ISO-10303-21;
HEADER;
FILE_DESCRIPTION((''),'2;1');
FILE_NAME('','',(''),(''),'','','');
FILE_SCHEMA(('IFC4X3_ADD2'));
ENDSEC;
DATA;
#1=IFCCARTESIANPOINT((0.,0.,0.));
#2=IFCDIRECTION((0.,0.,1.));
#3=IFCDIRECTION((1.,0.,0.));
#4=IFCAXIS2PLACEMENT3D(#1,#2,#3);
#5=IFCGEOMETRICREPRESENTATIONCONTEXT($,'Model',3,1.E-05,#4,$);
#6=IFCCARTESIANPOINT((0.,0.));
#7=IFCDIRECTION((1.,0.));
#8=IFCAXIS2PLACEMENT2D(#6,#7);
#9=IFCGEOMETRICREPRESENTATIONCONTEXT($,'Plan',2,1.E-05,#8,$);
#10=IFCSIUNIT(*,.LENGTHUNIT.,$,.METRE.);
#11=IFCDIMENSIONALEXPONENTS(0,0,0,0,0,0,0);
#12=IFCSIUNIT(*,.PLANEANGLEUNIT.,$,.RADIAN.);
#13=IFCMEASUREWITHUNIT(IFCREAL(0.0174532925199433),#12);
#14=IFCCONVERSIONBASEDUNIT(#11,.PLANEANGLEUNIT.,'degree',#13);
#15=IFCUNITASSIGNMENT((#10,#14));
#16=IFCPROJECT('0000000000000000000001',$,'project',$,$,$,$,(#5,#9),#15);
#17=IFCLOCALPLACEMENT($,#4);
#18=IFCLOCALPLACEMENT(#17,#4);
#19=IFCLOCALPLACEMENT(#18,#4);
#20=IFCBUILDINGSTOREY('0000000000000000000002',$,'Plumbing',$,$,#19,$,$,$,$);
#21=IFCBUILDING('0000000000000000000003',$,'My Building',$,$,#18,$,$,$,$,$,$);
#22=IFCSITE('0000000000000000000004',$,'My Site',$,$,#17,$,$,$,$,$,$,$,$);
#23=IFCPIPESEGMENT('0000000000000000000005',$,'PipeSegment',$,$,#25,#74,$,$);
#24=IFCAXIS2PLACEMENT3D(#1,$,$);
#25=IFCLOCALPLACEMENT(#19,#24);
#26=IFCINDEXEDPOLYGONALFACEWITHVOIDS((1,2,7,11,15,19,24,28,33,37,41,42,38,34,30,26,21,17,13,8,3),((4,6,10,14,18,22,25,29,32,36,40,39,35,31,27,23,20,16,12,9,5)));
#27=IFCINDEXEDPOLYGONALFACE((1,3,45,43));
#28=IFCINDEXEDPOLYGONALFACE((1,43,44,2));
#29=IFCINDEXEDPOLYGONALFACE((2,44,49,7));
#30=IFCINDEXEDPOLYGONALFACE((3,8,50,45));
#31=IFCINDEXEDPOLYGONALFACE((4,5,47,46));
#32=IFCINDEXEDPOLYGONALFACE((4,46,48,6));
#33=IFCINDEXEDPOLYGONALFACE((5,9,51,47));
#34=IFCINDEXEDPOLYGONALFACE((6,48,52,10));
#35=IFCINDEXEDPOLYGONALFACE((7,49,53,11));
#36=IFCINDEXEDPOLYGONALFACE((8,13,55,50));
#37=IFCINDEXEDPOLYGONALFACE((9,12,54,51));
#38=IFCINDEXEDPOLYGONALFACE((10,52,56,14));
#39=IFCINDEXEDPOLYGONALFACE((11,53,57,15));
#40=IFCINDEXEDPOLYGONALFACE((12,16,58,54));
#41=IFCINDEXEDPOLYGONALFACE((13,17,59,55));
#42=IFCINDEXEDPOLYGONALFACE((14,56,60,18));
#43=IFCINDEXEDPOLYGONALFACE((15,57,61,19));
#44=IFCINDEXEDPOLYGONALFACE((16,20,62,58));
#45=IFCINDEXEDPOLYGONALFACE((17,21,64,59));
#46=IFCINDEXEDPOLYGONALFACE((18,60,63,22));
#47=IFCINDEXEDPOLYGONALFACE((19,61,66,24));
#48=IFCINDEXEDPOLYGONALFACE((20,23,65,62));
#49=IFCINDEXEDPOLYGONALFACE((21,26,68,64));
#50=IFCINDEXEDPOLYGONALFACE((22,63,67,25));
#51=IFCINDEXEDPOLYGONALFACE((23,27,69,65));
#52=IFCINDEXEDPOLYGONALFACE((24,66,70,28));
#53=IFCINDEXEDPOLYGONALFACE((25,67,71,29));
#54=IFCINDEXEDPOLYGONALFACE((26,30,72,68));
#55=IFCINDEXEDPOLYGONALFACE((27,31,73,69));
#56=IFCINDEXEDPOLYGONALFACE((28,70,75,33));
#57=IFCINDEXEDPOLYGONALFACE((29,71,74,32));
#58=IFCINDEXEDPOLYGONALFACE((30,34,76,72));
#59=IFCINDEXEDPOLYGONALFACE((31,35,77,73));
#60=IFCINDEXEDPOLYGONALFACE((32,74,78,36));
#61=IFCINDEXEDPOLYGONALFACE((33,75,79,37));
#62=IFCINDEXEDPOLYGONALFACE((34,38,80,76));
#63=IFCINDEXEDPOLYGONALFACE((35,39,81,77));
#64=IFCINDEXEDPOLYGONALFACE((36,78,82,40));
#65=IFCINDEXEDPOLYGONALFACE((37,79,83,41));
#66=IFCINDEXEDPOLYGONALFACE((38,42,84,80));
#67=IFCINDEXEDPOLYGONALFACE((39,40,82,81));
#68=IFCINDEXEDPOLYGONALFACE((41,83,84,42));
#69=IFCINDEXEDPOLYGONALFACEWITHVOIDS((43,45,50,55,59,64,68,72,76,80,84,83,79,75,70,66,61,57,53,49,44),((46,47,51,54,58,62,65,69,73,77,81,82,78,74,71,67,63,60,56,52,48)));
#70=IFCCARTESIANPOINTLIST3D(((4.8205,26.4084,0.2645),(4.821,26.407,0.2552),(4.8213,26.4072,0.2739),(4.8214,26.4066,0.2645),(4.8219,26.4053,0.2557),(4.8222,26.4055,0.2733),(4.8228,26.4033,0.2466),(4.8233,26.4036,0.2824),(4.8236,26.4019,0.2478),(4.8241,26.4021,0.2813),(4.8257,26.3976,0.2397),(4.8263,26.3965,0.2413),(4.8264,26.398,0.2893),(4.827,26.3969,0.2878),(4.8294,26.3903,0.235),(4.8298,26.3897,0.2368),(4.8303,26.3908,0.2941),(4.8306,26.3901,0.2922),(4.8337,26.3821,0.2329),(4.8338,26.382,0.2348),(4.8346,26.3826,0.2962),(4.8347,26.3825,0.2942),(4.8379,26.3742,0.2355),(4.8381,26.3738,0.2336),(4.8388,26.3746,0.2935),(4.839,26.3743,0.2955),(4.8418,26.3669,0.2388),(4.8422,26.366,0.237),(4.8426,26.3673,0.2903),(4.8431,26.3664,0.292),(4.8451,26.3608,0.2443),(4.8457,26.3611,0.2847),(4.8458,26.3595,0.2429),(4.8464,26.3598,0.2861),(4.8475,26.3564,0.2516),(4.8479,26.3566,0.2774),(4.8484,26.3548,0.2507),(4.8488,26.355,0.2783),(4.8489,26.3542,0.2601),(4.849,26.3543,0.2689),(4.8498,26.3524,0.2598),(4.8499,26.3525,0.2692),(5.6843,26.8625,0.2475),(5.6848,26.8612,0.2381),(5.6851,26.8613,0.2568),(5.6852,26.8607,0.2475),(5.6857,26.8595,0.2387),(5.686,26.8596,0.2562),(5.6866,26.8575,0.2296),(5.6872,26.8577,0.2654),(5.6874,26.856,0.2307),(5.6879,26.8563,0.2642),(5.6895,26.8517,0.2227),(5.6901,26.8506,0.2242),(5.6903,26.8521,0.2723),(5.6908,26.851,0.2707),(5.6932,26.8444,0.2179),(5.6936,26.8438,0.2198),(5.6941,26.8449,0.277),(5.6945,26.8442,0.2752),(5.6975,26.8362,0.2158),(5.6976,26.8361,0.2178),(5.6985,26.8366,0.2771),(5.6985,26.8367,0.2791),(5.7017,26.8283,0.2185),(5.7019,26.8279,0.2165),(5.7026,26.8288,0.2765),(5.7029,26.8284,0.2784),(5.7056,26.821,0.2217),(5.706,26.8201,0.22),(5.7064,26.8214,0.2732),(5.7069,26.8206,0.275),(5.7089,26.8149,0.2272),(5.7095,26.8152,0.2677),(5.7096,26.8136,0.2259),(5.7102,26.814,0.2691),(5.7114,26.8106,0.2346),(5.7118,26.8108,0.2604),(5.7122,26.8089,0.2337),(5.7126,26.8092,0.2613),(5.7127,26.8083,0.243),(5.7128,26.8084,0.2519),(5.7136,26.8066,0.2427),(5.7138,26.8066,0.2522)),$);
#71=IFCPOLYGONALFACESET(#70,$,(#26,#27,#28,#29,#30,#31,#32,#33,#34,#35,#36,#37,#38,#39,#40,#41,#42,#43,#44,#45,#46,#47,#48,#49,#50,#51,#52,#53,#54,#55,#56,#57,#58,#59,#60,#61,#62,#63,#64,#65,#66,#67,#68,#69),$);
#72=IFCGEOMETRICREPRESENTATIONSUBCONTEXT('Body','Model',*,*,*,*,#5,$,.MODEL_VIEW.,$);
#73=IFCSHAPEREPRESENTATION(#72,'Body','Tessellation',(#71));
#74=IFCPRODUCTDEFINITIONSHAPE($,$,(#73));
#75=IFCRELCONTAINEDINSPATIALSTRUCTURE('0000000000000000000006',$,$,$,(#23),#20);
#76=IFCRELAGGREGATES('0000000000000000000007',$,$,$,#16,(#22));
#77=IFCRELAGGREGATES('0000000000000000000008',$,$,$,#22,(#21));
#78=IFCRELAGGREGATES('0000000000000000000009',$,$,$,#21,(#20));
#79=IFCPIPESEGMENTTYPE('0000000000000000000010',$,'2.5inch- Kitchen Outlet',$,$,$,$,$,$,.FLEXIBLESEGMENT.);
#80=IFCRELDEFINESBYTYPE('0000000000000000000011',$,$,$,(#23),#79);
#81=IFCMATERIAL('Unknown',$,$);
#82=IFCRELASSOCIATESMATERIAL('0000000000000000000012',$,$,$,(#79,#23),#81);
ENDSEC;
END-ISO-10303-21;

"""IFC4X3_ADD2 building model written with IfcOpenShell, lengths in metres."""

from ifc_helpers import new_model, entity, si_unit, converted_unit, frame, origin_with_axes, origin_2d_with_axis, place, context, subcontext, project, spatial, hollow_circle, extrude, material, material_profile, profile_set, profile_usage, type_object, element, save


model = new_model("IFC4X3_ADD2")

# Units and contexts
model_context = context("Model", 3, precision=1e-05, world=origin_with_axes())
plan_context = context("Plan", 2, precision=1e-05, world=origin_2d_with_axis())
body_context = subcontext(model_context, "Body", "Model", "MODEL_VIEW")
ifc_project = project(units=[si_unit("LENGTHUNIT", "METRE"), converted_unit("PLANEANGLEUNIT", "degree", entity("IfcReal", 0.0174532925199433), si_unit("PLANEANGLEUNIT", "RADIAN"), dimensions=[0, 0, 0, 0, 0, 0, 0])], contexts=[model_context, plan_context])

# Site, building, storey
site_placement = place(None, origin_with_axes())
site = spatial("IfcSite", under=ifc_project, at=site_placement, Name="My Site")
building_placement = place(site_placement, origin_with_axes())
building = spatial("IfcBuilding", under=site, at=building_placement, Name="My Building")
storey_placement = place(building_placement, origin_with_axes())
storey = spatial("IfcBuildingStorey", under=building, at=storey_placement, Name="Plumbing")

# Pipe segment
ifc_material_1 = material(Name="Unknown")
ifc_material_profile_1 = material_profile(ifc_material_1, hollow_circle(Radius=0.0318, WallThickness=0.002))
ifc_profile_set_1 = profile_set([ifc_material_profile_1], Name="kitchenwater")
ifc_material_profile_2 = material_profile(ifc_material_1, hollow_circle(Radius=0.0318, WallThickness=0.002))
ifc_profile_set_2 = profile_set([ifc_material_profile_2], Name="kitchenwater")
pipe_segment_type_1 = type_object("IfcPipeSegmentType", Name="2.5inch- Kitchen Outlet", PredefinedType="FLEXIBLESEGMENT", material=ifc_profile_set_2)
ifc_profile_usage_1 = profile_usage(ifc_profile_set_1)
pipe_segment_1_placement = place(storey_placement, frame((4.8353, 26.3803, 0.2645), z_axis=(0.885003, 0.465259, -0.017452), x_axis=(-0.46533, 0.885137, 0.0)))
element("IfcPipeSegment", 1, at=pipe_segment_1_placement, inside=storey, type_object=pipe_segment_type_1, material=ifc_profile_usage_1, Name="PipeSegment", context=body_context, shape_type="SweptSolid", body=[
    extrude(hollow_circle(Radius=0.0318, WallThickness=0.002), origin_with_axes(), (0.0, 0.0, 1.0), 0.9761),
])

save(model, "model.ifc")
